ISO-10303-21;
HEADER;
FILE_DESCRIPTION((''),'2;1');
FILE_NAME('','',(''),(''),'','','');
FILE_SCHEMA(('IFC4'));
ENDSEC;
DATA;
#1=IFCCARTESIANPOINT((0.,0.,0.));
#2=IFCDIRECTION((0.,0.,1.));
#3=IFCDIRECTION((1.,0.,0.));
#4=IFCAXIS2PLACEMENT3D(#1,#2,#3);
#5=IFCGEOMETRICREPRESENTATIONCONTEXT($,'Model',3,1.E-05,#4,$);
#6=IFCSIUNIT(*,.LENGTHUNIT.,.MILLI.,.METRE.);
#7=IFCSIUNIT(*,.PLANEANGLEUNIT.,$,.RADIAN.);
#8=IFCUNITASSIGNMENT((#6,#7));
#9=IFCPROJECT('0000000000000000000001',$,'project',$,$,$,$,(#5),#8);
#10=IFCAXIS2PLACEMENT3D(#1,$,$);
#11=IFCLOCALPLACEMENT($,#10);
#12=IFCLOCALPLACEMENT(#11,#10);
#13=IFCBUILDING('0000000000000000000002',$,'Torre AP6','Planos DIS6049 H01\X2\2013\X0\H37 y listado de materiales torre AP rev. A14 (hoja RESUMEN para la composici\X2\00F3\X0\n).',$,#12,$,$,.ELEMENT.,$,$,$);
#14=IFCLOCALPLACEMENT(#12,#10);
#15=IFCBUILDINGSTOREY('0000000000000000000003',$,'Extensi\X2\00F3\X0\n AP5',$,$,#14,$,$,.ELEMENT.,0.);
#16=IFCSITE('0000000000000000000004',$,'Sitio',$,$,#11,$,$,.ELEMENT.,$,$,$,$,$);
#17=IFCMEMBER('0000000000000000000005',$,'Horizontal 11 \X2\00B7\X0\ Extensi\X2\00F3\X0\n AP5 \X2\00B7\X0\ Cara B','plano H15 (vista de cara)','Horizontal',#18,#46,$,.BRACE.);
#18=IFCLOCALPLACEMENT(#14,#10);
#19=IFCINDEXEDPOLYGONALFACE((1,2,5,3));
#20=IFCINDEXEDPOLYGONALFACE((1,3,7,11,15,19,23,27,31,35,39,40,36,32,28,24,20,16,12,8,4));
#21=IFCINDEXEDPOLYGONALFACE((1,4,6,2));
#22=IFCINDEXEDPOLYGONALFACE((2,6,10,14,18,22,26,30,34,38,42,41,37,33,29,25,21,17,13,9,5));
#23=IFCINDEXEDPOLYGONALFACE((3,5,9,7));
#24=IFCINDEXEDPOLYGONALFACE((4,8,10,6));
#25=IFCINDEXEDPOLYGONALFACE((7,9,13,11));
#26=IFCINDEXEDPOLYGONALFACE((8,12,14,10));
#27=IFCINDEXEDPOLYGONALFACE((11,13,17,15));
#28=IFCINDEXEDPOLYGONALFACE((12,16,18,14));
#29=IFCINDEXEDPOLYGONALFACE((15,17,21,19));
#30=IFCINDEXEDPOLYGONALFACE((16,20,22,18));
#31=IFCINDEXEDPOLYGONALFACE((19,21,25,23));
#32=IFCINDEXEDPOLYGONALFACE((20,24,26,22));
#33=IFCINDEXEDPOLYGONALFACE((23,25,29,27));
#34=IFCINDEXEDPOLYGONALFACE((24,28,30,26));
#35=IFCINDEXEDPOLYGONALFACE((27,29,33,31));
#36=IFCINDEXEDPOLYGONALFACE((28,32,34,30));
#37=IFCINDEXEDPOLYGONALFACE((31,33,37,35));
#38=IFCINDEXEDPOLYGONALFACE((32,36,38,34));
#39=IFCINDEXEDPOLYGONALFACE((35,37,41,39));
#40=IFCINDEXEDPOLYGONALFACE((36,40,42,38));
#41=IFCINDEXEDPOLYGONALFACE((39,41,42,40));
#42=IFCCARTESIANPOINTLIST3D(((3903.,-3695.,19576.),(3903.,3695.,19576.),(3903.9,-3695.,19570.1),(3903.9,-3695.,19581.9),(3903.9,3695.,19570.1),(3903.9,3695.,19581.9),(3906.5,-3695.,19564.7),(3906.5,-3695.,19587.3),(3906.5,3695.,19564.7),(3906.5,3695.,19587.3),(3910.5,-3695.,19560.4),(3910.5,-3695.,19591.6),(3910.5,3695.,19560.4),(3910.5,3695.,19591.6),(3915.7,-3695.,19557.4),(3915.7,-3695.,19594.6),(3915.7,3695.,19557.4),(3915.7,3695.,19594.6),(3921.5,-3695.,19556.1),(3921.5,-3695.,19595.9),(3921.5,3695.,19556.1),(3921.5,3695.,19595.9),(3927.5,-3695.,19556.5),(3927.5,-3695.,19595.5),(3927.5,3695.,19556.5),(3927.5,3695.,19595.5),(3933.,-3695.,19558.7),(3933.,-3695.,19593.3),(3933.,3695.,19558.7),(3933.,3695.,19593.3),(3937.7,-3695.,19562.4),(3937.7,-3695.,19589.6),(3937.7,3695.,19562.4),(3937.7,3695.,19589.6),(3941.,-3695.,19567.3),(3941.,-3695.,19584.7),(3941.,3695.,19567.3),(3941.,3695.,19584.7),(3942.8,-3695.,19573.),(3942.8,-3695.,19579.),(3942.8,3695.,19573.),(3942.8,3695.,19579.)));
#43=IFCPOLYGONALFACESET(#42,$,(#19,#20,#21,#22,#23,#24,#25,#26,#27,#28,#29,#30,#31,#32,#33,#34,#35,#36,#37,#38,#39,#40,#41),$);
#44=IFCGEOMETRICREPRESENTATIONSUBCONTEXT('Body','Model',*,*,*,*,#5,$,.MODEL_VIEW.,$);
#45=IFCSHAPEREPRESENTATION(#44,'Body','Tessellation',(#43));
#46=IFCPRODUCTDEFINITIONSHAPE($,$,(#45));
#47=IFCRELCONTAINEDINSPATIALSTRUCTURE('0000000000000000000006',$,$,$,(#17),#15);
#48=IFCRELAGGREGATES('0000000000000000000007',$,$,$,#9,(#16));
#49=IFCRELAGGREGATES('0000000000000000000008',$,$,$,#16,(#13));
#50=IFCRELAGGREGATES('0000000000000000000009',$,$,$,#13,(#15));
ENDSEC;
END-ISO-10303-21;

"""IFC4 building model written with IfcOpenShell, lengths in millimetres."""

from ifc_helpers import new_model, si_unit, frame, origin, origin_with_axes, place, context, subcontext, project, spatial, circle, extrude, element, save


model = new_model("IFC4")

# Units and contexts
model_context = context("Model", 3, precision=1e-05, world=origin_with_axes())
body_context = subcontext(model_context, "Body", "Model", "MODEL_VIEW")
ifc_project = project(units=[si_unit("LENGTHUNIT", "METRE", prefix="MILLI"), si_unit("PLANEANGLEUNIT", "RADIAN")], contexts=[model_context])

# Site, building, storey
site_placement = place(None, origin())
site = spatial("IfcSite", under=ifc_project, at=site_placement, Name="Sitio", CompositionType="ELEMENT")
building_placement = place(site_placement, origin())
building = spatial("IfcBuilding", under=site, at=building_placement, Name="Torre AP6", Description="Planos DIS6049 H01–H37 y listado de materiales torre AP rev. A14 (hoja RESUMEN para la composición).", CompositionType="ELEMENT")
storey_placement = place(building_placement, origin())
storey = spatial("IfcBuildingStorey", under=building, at=storey_placement, Name="Extensión AP5", CompositionType="ELEMENT", Elevation=0.0)

# Member
for number, where, z_axis, x_axis, name in (
    (1, (3923.0, 3695.0, 19576.0), (0.0, -1.0, 0.0), (-1.0, 0.0, 0.0), "Horizontal 11 · Extensión AP5 · Cara B"),
):
    element("IfcMember", number, at=place(storey_placement, frame(where, z_axis=z_axis, x_axis=x_axis)), inside=storey, Name=name, Description="plano H15 (vista de cara)", ObjectType="Horizontal", PredefinedType="BRACE", context=body_context, shape_type="SweptSolid", body=[
        extrude(circle(Radius=20.0), None, (0.0, 0.0, 1.0), 7390.0),
    ])

save(model, "model.ifc")
